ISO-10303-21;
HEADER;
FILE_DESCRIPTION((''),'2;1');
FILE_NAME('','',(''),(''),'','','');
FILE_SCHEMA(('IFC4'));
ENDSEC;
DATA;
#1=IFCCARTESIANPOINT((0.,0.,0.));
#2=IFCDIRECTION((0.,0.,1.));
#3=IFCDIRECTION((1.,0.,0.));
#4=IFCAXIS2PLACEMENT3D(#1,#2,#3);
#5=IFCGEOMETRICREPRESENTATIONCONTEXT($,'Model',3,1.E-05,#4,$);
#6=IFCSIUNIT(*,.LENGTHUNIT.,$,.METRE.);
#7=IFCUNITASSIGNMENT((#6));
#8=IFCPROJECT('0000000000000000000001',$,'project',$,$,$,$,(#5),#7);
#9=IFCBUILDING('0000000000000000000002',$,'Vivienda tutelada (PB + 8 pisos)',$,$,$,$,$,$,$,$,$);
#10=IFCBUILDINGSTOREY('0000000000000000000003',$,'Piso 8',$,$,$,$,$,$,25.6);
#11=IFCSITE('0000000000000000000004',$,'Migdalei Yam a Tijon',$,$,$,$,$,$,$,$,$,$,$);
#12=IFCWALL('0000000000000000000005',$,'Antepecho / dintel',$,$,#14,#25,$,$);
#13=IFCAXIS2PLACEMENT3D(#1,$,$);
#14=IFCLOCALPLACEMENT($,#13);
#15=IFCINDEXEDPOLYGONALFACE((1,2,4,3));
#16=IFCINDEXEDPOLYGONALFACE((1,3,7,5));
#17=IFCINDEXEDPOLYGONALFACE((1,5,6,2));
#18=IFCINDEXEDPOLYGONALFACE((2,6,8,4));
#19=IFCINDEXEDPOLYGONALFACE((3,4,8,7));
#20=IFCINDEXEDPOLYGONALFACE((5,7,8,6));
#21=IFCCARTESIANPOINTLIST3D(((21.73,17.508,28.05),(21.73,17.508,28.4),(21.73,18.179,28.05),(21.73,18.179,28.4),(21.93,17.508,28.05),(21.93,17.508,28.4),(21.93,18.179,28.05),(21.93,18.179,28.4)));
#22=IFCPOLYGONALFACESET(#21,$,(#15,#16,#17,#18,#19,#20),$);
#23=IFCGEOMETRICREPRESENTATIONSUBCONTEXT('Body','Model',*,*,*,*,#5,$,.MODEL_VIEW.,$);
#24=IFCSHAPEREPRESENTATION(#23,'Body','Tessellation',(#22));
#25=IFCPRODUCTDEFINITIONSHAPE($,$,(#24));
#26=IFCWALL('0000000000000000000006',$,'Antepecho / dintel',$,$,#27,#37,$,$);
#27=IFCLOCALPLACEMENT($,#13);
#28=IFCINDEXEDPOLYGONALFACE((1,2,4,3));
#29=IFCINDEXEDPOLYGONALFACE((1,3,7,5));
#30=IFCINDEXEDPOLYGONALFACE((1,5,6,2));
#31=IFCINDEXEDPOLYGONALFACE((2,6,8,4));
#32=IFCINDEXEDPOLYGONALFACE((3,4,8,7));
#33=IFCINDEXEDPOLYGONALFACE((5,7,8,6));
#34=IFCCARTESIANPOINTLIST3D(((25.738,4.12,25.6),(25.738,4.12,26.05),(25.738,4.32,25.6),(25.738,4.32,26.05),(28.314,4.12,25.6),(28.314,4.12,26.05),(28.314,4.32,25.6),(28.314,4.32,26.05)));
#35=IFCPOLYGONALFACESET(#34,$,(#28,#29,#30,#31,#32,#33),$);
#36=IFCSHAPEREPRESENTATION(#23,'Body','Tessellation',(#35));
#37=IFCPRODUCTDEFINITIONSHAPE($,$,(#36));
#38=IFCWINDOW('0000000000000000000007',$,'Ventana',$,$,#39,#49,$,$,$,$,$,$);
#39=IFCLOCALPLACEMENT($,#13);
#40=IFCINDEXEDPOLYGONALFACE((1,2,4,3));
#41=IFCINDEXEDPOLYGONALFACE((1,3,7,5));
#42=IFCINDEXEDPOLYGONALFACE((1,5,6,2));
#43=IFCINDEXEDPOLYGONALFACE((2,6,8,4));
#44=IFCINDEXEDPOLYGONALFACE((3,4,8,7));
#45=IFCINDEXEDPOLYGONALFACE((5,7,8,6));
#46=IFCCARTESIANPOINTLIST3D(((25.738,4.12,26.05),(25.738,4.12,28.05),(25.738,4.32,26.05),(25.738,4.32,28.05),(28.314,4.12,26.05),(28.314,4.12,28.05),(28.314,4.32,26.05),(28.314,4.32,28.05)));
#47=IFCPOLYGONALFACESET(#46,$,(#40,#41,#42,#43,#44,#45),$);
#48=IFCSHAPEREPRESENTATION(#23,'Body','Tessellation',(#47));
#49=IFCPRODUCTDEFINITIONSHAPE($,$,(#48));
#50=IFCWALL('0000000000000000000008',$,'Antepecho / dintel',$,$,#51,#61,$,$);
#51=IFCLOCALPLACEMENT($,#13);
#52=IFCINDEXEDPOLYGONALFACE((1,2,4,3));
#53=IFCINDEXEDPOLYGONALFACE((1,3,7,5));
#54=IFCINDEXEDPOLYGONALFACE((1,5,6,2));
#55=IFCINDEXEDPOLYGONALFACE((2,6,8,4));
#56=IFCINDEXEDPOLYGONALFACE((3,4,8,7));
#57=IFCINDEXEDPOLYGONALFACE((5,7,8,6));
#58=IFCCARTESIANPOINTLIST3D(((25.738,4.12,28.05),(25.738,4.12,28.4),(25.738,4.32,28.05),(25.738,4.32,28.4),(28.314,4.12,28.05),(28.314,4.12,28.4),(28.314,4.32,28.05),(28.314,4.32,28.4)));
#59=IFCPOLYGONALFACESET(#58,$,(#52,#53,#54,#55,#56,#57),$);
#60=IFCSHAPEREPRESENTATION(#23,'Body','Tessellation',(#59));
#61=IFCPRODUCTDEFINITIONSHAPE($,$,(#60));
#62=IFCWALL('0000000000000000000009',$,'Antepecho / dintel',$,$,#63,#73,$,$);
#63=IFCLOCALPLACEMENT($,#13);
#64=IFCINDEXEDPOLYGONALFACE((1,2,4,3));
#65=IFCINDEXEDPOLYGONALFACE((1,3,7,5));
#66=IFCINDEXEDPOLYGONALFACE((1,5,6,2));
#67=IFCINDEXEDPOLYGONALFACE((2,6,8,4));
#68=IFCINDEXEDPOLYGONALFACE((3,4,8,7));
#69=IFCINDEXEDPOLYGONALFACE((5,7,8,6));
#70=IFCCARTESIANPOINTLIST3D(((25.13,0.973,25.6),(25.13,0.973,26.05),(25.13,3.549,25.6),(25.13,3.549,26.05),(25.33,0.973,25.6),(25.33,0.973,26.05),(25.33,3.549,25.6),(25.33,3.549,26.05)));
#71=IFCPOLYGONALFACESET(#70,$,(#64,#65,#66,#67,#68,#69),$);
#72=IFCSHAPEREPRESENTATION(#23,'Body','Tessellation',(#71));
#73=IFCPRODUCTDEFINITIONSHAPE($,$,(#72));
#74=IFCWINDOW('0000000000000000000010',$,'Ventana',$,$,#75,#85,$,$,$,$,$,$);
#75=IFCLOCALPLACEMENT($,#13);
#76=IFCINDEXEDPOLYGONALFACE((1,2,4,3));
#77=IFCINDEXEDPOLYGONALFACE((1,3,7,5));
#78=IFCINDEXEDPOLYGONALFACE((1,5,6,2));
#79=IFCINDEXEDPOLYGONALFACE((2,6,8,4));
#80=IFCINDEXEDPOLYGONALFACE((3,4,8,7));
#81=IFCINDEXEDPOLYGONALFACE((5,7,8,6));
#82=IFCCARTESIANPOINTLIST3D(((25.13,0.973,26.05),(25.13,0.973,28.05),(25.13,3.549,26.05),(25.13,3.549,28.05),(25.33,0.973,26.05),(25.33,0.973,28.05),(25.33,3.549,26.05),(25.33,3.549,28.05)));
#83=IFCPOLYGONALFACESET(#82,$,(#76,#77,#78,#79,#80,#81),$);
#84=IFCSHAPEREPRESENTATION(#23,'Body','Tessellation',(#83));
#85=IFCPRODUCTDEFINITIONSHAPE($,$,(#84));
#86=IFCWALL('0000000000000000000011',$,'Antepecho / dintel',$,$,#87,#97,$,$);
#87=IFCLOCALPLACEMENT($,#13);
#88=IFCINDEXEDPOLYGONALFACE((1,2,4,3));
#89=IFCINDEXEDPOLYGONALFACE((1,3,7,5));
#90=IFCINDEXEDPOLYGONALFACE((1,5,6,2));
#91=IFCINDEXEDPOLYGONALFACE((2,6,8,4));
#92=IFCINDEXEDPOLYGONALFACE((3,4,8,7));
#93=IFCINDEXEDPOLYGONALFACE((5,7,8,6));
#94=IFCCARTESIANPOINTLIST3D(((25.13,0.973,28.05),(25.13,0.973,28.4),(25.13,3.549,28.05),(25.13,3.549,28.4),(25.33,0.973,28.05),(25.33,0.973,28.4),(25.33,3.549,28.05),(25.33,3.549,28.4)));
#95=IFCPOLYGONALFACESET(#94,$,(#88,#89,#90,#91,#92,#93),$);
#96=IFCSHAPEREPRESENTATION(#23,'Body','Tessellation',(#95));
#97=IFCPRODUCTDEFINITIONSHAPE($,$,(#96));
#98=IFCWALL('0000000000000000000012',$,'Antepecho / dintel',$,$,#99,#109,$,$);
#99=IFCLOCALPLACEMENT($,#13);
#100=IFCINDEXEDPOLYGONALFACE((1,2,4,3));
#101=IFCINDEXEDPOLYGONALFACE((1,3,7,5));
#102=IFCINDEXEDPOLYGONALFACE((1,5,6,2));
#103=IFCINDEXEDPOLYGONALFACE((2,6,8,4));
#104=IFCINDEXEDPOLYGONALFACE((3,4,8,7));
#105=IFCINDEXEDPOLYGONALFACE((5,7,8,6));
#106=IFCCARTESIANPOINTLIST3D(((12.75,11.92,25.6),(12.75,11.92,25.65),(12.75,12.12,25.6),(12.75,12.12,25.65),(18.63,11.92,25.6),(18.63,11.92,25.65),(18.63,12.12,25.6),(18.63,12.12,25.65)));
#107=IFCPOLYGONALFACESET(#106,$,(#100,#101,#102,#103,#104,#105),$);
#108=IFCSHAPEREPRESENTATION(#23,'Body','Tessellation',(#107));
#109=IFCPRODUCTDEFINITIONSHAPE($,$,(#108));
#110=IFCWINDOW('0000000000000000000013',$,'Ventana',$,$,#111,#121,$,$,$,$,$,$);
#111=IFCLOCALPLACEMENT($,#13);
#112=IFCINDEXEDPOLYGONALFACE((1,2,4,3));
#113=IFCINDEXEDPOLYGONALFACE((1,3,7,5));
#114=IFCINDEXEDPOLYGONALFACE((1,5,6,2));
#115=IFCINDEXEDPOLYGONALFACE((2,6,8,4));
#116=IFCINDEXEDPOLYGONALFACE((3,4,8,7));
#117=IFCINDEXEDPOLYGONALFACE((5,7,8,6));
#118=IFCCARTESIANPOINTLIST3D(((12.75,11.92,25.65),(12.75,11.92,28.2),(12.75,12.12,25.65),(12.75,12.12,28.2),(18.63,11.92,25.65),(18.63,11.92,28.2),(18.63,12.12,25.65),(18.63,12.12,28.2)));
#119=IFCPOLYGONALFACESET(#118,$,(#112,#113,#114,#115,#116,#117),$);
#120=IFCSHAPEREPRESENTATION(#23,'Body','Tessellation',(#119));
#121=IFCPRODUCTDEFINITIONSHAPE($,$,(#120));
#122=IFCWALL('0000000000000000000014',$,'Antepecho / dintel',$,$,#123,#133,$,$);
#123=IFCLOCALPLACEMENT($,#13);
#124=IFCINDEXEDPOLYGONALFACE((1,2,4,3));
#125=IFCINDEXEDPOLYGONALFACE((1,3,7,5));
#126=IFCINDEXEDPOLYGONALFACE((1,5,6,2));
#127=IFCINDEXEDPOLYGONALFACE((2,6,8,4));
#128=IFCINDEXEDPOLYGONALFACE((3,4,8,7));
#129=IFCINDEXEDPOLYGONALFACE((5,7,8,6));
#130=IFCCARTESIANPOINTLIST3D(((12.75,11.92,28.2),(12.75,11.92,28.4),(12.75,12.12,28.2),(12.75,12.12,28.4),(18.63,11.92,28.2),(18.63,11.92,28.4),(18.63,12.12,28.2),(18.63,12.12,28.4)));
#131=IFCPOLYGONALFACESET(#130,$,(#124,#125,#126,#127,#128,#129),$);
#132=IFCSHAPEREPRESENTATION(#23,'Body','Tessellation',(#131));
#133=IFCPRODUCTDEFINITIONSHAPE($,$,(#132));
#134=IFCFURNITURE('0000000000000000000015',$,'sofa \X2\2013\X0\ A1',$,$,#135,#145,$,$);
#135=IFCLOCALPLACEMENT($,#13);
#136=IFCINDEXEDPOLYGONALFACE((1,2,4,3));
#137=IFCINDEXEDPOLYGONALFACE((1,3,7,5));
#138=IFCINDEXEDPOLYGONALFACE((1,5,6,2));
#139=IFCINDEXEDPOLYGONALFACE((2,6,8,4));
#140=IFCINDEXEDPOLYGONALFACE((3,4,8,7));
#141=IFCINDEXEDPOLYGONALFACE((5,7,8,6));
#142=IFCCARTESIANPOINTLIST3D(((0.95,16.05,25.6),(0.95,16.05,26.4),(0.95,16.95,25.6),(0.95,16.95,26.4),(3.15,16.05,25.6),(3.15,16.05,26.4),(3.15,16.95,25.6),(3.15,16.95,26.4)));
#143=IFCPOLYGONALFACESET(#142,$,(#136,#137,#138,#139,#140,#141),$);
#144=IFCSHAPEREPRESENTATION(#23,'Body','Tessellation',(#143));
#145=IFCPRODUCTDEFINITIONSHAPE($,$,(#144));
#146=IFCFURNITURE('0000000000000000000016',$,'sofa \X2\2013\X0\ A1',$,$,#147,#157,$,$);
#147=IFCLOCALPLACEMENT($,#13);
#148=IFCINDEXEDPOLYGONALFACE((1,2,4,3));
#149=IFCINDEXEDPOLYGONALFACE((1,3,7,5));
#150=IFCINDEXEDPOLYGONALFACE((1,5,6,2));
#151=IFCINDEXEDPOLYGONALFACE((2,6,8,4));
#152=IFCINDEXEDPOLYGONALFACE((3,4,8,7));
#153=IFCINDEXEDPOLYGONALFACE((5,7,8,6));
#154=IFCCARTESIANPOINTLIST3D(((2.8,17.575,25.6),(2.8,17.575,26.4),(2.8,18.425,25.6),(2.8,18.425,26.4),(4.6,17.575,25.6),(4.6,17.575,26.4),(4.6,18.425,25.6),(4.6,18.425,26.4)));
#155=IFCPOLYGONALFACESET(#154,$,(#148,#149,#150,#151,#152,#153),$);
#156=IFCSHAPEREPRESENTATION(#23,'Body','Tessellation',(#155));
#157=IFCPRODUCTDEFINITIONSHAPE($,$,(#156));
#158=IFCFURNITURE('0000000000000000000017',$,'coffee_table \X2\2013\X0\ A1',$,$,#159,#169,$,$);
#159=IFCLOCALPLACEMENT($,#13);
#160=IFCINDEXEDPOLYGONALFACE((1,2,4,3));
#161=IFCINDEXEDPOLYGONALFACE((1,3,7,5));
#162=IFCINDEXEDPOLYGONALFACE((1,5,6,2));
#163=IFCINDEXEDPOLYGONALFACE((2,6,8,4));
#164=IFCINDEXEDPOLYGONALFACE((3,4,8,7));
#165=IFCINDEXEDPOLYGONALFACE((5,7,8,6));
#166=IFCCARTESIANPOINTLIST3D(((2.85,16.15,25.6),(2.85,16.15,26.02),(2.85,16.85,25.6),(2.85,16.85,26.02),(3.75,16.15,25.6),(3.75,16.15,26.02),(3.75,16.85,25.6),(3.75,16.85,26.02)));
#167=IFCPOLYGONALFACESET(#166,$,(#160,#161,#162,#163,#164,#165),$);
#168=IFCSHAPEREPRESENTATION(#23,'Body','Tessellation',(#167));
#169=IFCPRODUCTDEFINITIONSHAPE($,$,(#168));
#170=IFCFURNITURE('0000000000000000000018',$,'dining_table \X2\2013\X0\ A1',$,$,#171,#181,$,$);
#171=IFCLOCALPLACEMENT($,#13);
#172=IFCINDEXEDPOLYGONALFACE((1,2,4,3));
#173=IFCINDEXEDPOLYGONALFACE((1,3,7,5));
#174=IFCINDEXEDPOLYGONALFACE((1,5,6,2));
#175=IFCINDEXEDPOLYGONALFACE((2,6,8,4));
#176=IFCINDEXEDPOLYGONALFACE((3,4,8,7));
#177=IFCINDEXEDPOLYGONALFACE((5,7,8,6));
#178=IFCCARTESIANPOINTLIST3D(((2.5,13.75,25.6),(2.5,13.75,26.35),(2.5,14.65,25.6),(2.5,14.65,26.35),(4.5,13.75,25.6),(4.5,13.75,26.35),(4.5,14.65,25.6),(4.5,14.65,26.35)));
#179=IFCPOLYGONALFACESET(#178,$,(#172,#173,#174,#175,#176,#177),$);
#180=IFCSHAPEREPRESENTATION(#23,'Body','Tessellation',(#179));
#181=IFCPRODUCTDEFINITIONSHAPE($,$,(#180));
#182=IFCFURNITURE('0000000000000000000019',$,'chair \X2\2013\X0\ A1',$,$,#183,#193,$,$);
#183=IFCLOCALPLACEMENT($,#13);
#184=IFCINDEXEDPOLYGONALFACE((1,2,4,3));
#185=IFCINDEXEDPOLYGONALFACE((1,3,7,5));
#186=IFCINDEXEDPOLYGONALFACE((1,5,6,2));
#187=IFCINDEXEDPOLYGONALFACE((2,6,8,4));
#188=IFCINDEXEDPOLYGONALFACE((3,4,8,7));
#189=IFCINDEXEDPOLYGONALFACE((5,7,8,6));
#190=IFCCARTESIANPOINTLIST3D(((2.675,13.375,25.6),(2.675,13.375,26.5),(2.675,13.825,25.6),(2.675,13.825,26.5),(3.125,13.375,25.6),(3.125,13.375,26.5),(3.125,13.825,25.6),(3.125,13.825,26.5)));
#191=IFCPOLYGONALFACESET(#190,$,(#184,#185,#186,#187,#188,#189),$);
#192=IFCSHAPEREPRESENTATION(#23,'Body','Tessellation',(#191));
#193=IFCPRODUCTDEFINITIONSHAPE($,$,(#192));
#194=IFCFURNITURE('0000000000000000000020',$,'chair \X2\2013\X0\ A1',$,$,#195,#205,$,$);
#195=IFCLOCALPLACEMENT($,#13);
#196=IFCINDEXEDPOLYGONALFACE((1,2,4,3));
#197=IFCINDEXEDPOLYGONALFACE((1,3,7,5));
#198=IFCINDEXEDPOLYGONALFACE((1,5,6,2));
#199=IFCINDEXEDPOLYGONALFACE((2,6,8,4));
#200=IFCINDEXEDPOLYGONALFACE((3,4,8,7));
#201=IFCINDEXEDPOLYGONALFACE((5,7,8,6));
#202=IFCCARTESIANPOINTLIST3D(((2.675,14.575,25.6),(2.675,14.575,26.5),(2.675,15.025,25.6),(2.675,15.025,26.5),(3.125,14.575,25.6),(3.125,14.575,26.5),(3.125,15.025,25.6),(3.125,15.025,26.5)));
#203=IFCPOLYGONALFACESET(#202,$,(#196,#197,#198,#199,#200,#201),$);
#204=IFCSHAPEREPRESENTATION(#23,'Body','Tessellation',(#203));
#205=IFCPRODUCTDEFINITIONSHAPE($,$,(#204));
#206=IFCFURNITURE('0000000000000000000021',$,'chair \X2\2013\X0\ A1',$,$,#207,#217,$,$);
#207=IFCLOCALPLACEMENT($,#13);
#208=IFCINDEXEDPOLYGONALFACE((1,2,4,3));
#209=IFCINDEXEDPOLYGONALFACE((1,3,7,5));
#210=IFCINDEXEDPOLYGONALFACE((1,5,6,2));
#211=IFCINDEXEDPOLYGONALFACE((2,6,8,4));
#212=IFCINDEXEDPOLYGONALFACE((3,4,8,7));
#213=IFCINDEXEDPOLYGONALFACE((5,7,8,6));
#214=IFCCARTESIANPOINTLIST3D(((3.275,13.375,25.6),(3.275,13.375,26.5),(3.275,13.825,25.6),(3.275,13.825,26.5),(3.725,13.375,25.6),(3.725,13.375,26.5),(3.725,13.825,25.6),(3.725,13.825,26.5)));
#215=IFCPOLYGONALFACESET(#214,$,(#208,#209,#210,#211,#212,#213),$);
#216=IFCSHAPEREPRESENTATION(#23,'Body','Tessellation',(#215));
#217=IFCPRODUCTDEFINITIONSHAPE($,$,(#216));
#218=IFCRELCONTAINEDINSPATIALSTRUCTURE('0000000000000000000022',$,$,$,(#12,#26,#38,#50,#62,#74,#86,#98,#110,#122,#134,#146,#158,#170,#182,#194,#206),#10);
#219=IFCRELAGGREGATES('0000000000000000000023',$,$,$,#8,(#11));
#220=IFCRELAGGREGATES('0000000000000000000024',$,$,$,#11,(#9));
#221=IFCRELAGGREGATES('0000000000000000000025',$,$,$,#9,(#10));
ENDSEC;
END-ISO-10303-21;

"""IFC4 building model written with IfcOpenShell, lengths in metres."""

from ifc_helpers import new_model, si_unit, frame, origin_with_axes, context, subcontext, project, spatial, line, indexed_curve, outline, extrude, element, save


model = new_model("IFC4")

# Units and contexts
model_context = context("Model", 3, precision=1e-05, world=origin_with_axes())
body_context = subcontext(model_context, "Body", "Model", "MODEL_VIEW")
ifc_project = project(units=[si_unit("LENGTHUNIT", "METRE")], contexts=[model_context])

# Site, building, storey
site = spatial("IfcSite", under=ifc_project, Name="Migdalei Yam a Tijon")
building = spatial("IfcBuilding", under=site, Name="Vivienda tutelada (PB + 8 pisos)")
storey = spatial("IfcBuildingStorey", under=building, Name="Piso 8", Elevation=25.6)

# Walls
element("IfcWall", 1, inside=storey, Name="Antepecho / dintel", context=body_context, shape_type="SweptSolid", body=[
    extrude(outline(indexed_curve([(0.0, 0.0), (0.2, 0.0), (0.2, 0.671), (0.0, 0.671)], segments=[line(1, 2, 3, 4, 1)])), frame((21.73, 17.508, 28.05), z_axis=(0.0, 0.0, 1.0), x_axis=(1.0, 0.0, 0.0)), (0.0, 0.0, 1.0), 0.35),
])
element("IfcWall", 2, inside=storey, Name="Antepecho / dintel", context=body_context, shape_type="SweptSolid", body=[
    extrude(outline(indexed_curve([(0.0, 0.0), (2.576, 0.0), (2.576, 0.2), (0.0, 0.2)], segments=[line(1, 2, 3, 4, 1)])), frame((25.738, 4.12, 25.6), z_axis=(0.0, 0.0, 1.0), x_axis=(1.0, 0.0, 0.0)), (0.0, 0.0, 1.0), 0.45),
])

# Window
element("IfcWindow", 3, inside=storey, Name="Ventana", context=body_context, shape_type="SweptSolid", body=[
    extrude(outline(indexed_curve([(0.0, 0.0), (2.576, 0.0), (2.576, 0.2), (0.0, 0.2)], segments=[line(1, 2, 3, 4, 1)])), frame((25.738, 4.12, 26.05), z_axis=(0.0, 0.0, 1.0), x_axis=(1.0, 0.0, 0.0)), (0.0, 0.0, 1.0), 2.0),
])

# Walls
element("IfcWall", 4, inside=storey, Name="Antepecho / dintel", context=body_context, shape_type="SweptSolid", body=[
    extrude(outline(indexed_curve([(0.0, 0.0), (2.576, 0.0), (2.576, 0.2), (0.0, 0.2)], segments=[line(1, 2, 3, 4, 1)])), frame((25.738, 4.12, 28.05), z_axis=(0.0, 0.0, 1.0), x_axis=(1.0, 0.0, 0.0)), (0.0, 0.0, 1.0), 0.35),
])
element("IfcWall", 5, inside=storey, Name="Antepecho / dintel", context=body_context, shape_type="SweptSolid", body=[
    extrude(outline(indexed_curve([(0.0, 0.0), (0.2, 0.0), (0.2, 2.576), (0.0, 2.576)], segments=[line(1, 2, 3, 4, 1)])), frame((25.13, 0.973, 25.6), z_axis=(0.0, 0.0, 1.0), x_axis=(1.0, 0.0, 0.0)), (0.0, 0.0, 1.0), 0.45),
])

# Window
element("IfcWindow", 6, inside=storey, Name="Ventana", context=body_context, shape_type="SweptSolid", body=[
    extrude(outline(indexed_curve([(0.0, 0.0), (0.2, 0.0), (0.2, 2.576), (0.0, 2.576)], segments=[line(1, 2, 3, 4, 1)])), frame((25.13, 0.973, 26.05), z_axis=(0.0, 0.0, 1.0), x_axis=(1.0, 0.0, 0.0)), (0.0, 0.0, 1.0), 2.0),
])

# Walls
element("IfcWall", 7, inside=storey, Name="Antepecho / dintel", context=body_context, shape_type="SweptSolid", body=[
    extrude(outline(indexed_curve([(0.0, 0.0), (0.2, 0.0), (0.2, 2.576), (0.0, 2.576)], segments=[line(1, 2, 3, 4, 1)])), frame((25.13, 0.973, 28.05), z_axis=(0.0, 0.0, 1.0), x_axis=(1.0, 0.0, 0.0)), (0.0, 0.0, 1.0), 0.35),
])
element("IfcWall", 8, inside=storey, Name="Antepecho / dintel", context=body_context, shape_type="SweptSolid", body=[
    extrude(outline(indexed_curve([(0.0, 0.0), (5.88, 0.0), (5.88, 0.2), (0.0, 0.2)], segments=[line(1, 2, 3, 4, 1)])), frame((12.75, 11.92, 25.6), z_axis=(0.0, 0.0, 1.0), x_axis=(1.0, 0.0, 0.0)), (0.0, 0.0, 1.0), 0.05),
])

# Window
element("IfcWindow", 9, inside=storey, Name="Ventana", context=body_context, shape_type="SweptSolid", body=[
    extrude(outline(indexed_curve([(0.0, 0.0), (5.88, 0.0), (5.88, 0.2), (0.0, 0.2)], segments=[line(1, 2, 3, 4, 1)])), frame((12.75, 11.92, 25.65), z_axis=(0.0, 0.0, 1.0), x_axis=(1.0, 0.0, 0.0)), (0.0, 0.0, 1.0), 2.55),
])

# Wall
element("IfcWall", 10, inside=storey, Name="Antepecho / dintel", context=body_context, shape_type="SweptSolid", body=[
    extrude(outline(indexed_curve([(0.0, 0.0), (5.88, 0.0), (5.88, 0.2), (0.0, 0.2)], segments=[line(1, 2, 3, 4, 1)])), frame((12.75, 11.92, 28.2), z_axis=(0.0, 0.0, 1.0), x_axis=(1.0, 0.0, 0.0)), (0.0, 0.0, 1.0), 0.2),
])

# Furniture
element("IfcFurniture", 11, inside=storey, Name="sofa – A1", context=body_context, shape_type="SweptSolid", body=[
    extrude(outline(indexed_curve([(0.0, 0.0), (2.2, 0.0), (2.2, 0.9), (0.0, 0.9)], segments=[line(1, 2, 3, 4, 1)])), frame((0.95, 16.05, 25.6), z_axis=(0.0, 0.0, 1.0), x_axis=(1.0, 0.0, 0.0)), (0.0, 0.0, 1.0), 0.8),
])
element("IfcFurniture", 12, inside=storey, Name="sofa – A1", context=body_context, shape_type="SweptSolid", body=[
    extrude(outline(indexed_curve([(0.0, 0.0), (1.8, 0.0), (1.8, 0.85), (0.0, 0.85)], segments=[line(1, 2, 3, 4, 1)])), frame((2.8, 17.575, 25.6), z_axis=(0.0, 0.0, 1.0), x_axis=(1.0, 0.0, 0.0)), (0.0, 0.0, 1.0), 0.8),
])
element("IfcFurniture", 13, inside=storey, Name="coffee_table – A1", context=body_context, shape_type="SweptSolid", body=[
    extrude(outline(indexed_curve([(0.0, 0.0), (0.9, 0.0), (0.9, 0.7), (0.0, 0.7)], segments=[line(1, 2, 3, 4, 1)])), frame((2.85, 16.15, 25.6), z_axis=(0.0, 0.0, 1.0), x_axis=(1.0, 0.0, 0.0)), (0.0, 0.0, 1.0), 0.42),
])
element("IfcFurniture", 14, inside=storey, Name="dining_table – A1", context=body_context, shape_type="SweptSolid", body=[
    extrude(outline(indexed_curve([(0.0, 0.0), (2.0, 0.0), (2.0, 0.9), (0.0, 0.9)], segments=[line(1, 2, 3, 4, 1)])), frame((2.5, 13.75, 25.6), z_axis=(0.0, 0.0, 1.0), x_axis=(1.0, 0.0, 0.0)), (0.0, 0.0, 1.0), 0.75),
])
element("IfcFurniture", 15, inside=storey, Name="chair – A1", context=body_context, shape_type="SweptSolid", body=[
    extrude(outline(indexed_curve([(0.0, 0.0), (0.45, 0.0), (0.45, 0.45), (0.0, 0.45)], segments=[line(1, 2, 3, 4, 1)])), frame((2.675, 13.375, 25.6), z_axis=(0.0, 0.0, 1.0), x_axis=(1.0, 0.0, 0.0)), (0.0, 0.0, 1.0), 0.9),
])
element("IfcFurniture", 16, inside=storey, Name="chair – A1", context=body_context, shape_type="SweptSolid", body=[
    extrude(outline(indexed_curve([(0.0, 0.0), (0.45, 0.0), (0.45, 0.45), (0.0, 0.45)], segments=[line(1, 2, 3, 4, 1)])), frame((2.675, 14.575, 25.6), z_axis=(0.0, 0.0, 1.0), x_axis=(1.0, 0.0, 0.0)), (0.0, 0.0, 1.0), 0.9),
])
element("IfcFurniture", 17, inside=storey, Name="chair – A1", context=body_context, shape_type="SweptSolid", body=[
    extrude(outline(indexed_curve([(0.0, 0.0), (0.45, 0.0), (0.45, 0.45), (0.0, 0.45)], segments=[line(1, 2, 3, 4, 1)])), frame((3.275, 13.375, 25.6), z_axis=(0.0, 0.0, 1.0), x_axis=(1.0, 0.0, 0.0)), (0.0, 0.0, 1.0), 0.9),
])

save(model, "model.ifc")
